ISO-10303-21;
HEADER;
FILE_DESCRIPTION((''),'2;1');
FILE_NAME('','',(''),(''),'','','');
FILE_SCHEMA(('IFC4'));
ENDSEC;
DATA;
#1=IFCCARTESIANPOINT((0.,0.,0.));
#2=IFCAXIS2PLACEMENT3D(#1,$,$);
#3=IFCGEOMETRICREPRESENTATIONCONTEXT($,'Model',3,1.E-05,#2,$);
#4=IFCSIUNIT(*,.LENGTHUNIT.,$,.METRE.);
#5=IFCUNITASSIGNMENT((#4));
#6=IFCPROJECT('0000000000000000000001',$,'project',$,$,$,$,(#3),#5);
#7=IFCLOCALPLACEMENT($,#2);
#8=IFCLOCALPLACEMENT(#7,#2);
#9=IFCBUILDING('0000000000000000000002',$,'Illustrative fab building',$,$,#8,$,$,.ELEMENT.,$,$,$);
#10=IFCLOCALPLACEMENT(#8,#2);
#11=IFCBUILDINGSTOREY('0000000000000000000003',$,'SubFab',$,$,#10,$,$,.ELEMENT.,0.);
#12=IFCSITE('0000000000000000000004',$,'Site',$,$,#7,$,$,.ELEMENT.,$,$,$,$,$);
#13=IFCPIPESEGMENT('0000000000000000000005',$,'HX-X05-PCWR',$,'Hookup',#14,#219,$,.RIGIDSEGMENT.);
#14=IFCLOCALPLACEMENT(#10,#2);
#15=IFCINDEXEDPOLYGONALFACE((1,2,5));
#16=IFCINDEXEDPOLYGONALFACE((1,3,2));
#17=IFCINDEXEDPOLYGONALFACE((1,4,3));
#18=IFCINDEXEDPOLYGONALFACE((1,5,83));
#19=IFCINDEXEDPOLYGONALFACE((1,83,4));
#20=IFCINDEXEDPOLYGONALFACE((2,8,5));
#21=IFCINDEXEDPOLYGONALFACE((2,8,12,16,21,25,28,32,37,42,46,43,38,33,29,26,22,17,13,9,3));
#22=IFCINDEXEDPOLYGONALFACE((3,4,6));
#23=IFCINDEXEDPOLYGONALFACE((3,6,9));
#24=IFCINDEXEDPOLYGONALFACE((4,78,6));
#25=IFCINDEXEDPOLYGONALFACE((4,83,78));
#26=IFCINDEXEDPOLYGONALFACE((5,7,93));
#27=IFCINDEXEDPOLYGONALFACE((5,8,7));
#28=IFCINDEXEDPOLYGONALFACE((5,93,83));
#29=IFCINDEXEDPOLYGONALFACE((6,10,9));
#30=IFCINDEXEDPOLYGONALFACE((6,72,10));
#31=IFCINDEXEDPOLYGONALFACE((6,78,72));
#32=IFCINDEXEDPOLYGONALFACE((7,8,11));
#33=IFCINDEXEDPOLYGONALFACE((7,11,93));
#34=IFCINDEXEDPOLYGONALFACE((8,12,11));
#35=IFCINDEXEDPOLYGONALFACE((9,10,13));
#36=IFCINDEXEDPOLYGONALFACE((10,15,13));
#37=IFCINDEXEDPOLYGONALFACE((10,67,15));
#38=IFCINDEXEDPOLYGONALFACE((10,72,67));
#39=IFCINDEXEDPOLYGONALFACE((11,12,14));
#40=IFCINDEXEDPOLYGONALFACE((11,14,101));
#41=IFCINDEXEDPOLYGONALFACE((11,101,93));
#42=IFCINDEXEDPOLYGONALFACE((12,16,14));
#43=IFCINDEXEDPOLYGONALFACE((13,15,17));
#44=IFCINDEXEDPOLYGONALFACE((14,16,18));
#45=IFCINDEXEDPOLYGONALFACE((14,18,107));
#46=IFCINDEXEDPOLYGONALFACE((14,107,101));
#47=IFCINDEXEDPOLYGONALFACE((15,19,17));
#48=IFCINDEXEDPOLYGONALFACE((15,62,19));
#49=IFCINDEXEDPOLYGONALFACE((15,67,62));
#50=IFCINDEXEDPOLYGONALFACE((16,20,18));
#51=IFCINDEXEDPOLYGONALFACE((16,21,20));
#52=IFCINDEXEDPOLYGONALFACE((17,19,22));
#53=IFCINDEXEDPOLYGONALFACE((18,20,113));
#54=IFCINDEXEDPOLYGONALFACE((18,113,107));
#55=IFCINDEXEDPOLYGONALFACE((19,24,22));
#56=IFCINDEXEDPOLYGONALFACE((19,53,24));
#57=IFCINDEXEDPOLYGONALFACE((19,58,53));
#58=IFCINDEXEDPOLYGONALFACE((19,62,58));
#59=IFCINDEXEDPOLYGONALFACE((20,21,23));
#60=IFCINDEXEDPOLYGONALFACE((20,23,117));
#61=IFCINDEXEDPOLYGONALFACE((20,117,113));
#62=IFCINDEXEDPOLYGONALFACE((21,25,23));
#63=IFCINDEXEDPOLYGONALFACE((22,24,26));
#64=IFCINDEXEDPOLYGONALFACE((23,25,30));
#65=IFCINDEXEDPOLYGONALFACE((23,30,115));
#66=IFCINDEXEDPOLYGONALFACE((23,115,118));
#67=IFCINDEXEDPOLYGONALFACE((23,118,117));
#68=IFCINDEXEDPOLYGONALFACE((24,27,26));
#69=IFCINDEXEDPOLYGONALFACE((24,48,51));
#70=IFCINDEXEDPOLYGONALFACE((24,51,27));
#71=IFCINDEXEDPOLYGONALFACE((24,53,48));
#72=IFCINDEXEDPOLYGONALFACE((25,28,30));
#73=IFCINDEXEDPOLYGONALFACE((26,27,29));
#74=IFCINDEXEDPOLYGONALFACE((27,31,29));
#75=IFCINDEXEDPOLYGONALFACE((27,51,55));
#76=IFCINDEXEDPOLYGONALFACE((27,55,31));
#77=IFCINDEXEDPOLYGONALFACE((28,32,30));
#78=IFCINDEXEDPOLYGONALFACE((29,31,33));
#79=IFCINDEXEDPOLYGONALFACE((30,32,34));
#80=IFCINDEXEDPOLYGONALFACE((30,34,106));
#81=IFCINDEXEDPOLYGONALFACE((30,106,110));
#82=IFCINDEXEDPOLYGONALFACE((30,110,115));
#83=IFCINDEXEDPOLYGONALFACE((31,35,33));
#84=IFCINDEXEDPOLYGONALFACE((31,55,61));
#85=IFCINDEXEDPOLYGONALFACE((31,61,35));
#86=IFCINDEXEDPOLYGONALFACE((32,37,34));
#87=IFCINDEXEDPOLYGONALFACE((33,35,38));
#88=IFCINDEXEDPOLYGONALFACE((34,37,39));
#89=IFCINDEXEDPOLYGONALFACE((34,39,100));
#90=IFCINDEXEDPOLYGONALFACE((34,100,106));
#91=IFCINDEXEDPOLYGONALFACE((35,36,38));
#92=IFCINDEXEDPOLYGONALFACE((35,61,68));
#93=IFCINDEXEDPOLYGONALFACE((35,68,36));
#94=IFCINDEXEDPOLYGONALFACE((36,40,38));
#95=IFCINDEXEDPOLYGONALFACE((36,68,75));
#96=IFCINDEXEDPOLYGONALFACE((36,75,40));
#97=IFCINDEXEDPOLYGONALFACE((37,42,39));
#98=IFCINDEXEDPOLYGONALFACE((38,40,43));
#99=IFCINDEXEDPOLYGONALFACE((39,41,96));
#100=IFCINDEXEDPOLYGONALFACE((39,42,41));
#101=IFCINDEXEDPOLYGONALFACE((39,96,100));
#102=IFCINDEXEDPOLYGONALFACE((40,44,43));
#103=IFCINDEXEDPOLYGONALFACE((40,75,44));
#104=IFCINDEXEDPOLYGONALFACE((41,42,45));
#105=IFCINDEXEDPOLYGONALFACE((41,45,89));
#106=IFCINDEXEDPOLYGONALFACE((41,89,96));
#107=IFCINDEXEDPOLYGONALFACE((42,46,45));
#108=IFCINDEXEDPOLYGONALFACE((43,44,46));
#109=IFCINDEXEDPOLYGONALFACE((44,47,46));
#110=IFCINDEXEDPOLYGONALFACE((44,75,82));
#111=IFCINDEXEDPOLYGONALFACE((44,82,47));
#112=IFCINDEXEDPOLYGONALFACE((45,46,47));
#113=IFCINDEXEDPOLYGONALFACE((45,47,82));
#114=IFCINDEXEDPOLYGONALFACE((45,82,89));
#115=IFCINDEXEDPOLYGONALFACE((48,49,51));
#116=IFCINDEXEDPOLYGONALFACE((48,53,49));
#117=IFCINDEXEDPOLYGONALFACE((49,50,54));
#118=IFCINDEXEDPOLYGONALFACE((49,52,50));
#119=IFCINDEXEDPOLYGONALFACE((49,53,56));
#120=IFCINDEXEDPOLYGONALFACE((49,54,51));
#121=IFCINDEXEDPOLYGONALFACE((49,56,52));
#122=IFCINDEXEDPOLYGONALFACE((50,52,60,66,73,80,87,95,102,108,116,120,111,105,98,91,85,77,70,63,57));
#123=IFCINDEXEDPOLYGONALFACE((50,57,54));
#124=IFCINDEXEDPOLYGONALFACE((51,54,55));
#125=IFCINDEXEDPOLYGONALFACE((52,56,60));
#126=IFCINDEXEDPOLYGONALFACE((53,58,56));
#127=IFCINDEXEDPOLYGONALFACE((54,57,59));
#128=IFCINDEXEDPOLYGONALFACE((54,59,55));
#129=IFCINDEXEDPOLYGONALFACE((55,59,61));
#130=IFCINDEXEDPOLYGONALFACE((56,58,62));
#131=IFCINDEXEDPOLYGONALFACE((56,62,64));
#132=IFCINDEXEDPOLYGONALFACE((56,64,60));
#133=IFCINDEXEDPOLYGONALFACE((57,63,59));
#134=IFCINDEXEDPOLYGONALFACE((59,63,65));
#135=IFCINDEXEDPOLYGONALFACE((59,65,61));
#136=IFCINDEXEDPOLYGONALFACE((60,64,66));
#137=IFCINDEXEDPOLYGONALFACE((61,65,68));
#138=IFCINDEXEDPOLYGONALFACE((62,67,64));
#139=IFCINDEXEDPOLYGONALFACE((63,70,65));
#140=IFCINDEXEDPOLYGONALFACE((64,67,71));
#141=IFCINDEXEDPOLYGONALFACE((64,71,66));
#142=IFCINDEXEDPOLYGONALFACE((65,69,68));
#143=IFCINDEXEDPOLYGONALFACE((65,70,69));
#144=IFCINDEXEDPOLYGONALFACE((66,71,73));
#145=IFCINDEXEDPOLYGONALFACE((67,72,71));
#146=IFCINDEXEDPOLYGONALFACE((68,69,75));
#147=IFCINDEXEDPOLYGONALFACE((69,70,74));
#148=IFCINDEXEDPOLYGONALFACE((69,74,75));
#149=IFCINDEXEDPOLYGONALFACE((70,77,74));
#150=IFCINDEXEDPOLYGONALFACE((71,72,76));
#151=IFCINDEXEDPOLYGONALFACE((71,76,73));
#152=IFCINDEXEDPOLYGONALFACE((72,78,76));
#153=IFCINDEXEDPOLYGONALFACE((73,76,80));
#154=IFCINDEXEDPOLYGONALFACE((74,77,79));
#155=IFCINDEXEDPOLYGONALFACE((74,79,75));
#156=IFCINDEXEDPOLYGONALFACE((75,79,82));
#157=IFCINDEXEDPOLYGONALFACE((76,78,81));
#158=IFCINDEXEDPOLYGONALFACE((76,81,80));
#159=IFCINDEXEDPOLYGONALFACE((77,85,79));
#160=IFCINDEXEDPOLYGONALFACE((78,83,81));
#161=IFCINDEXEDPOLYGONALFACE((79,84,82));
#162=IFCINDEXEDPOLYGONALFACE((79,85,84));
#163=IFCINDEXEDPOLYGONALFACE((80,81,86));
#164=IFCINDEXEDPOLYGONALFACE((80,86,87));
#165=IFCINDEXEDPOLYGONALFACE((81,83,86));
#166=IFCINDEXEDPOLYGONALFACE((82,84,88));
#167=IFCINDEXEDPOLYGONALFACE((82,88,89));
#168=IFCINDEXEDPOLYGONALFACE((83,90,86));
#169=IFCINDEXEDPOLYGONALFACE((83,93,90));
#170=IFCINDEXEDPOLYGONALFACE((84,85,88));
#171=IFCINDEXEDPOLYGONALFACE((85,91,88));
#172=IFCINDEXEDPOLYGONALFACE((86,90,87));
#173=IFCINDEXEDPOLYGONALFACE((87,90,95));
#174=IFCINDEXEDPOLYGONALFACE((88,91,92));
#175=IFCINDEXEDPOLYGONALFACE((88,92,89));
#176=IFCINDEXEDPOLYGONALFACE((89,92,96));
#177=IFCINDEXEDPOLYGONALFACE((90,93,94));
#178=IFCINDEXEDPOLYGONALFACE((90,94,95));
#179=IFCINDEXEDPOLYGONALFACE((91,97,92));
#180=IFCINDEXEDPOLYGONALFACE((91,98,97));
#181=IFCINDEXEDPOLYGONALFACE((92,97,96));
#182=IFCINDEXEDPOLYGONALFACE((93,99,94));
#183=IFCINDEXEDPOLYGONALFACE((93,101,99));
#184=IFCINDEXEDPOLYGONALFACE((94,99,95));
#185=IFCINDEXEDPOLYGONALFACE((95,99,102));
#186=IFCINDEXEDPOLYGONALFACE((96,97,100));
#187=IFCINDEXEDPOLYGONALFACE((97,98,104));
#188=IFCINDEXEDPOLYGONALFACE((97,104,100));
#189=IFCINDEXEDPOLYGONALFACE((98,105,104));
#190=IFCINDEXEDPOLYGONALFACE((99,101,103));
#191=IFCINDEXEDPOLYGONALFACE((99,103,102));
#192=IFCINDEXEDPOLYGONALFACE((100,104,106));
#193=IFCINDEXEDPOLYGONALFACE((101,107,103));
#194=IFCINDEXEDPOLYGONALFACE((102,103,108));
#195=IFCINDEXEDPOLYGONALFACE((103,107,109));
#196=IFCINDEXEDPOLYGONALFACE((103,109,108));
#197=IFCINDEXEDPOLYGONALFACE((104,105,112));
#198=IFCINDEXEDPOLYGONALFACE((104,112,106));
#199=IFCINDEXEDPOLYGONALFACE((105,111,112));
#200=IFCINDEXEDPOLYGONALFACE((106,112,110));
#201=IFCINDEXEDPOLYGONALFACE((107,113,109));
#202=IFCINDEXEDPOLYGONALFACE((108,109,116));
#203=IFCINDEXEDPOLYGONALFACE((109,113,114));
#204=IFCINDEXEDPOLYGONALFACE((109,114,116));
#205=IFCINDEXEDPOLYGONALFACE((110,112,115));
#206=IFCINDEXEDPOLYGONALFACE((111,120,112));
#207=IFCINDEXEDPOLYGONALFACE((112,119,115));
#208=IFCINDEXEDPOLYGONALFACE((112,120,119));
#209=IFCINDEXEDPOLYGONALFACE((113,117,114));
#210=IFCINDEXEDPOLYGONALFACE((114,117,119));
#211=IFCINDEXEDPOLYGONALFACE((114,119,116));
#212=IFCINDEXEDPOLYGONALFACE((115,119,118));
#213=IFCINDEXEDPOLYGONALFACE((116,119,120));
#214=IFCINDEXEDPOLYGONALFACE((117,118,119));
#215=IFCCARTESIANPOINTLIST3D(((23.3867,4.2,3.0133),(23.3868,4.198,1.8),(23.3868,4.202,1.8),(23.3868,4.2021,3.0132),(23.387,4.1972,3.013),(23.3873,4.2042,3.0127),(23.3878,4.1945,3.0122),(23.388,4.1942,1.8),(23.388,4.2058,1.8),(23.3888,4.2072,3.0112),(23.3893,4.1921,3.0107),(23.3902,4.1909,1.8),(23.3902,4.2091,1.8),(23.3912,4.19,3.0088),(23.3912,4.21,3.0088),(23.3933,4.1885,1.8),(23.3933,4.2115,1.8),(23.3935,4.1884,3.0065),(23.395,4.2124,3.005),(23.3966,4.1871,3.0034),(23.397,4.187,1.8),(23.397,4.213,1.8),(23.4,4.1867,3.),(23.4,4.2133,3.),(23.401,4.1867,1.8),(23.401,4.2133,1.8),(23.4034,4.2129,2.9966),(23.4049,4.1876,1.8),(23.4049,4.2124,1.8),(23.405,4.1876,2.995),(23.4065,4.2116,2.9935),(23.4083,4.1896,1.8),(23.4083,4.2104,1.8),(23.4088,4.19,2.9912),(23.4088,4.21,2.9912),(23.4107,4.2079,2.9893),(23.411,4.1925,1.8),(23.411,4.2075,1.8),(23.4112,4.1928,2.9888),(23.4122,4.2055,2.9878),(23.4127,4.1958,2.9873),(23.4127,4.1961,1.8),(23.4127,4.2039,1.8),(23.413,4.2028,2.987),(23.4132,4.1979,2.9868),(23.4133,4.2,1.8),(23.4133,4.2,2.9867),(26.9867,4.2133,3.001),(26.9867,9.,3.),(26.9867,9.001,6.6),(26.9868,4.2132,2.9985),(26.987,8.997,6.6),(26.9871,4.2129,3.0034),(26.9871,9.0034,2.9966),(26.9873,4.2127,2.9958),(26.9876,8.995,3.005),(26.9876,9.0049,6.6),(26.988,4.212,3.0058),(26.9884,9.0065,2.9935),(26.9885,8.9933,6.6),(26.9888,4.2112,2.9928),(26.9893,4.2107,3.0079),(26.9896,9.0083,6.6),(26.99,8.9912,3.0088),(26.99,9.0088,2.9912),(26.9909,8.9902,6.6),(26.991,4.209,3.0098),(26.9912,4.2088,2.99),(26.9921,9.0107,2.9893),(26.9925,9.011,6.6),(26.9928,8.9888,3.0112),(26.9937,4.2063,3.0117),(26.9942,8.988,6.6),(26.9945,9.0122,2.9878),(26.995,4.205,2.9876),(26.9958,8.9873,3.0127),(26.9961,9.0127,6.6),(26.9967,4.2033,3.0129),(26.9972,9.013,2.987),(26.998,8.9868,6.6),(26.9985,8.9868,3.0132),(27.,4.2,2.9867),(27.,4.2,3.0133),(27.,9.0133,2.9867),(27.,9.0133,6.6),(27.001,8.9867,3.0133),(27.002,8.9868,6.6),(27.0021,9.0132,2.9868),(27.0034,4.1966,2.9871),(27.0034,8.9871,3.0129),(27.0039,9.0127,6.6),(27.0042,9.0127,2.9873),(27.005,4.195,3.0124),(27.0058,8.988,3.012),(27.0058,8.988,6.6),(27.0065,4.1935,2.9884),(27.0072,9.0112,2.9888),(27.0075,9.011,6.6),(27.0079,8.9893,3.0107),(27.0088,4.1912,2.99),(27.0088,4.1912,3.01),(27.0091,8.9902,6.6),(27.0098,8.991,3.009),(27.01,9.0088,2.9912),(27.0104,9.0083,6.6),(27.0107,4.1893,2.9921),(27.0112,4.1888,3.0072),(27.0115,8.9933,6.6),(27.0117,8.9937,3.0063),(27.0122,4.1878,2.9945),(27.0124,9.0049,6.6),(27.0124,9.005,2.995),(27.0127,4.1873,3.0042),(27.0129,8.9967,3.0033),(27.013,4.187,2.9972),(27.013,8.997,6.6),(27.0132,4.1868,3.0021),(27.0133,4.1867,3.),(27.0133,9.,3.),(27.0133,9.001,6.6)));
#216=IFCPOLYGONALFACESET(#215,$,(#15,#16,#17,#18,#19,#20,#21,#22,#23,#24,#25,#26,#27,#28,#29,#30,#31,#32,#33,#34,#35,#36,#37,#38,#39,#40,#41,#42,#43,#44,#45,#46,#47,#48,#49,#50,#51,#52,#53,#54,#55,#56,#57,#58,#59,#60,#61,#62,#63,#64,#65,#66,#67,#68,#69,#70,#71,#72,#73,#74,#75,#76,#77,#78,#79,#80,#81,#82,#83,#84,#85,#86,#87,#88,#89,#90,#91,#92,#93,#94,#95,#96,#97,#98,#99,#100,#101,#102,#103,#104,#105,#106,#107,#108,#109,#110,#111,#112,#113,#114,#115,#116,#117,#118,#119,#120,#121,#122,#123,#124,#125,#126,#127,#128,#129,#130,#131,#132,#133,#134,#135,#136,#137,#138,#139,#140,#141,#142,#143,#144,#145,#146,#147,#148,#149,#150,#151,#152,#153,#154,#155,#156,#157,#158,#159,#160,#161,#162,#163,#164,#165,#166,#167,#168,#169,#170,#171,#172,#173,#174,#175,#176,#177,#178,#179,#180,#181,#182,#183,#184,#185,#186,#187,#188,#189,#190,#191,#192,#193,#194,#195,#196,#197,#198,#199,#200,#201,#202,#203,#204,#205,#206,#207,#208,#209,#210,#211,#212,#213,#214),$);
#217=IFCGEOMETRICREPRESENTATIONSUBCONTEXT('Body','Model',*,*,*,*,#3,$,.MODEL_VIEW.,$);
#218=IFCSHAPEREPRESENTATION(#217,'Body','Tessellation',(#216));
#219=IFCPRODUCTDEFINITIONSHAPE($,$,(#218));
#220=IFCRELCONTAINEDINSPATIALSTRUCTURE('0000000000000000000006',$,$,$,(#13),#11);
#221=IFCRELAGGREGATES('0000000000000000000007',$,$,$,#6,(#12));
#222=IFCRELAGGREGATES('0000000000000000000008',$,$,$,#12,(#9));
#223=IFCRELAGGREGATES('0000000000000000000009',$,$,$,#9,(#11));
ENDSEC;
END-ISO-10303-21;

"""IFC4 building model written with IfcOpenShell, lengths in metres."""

from ifc_helpers import new_model, entity, si_unit, origin, place, context, subcontext, project, spatial, element, save


model = new_model("IFC4")

# Units and contexts
model_context = context("Model", 3, precision=1e-05, world=origin())
body_context = subcontext(model_context, "Body", "Model", "MODEL_VIEW")
ifc_project = project(units=[si_unit("LENGTHUNIT", "METRE")], contexts=[model_context])

# Site, building, storey
site_placement = place(None, origin())
site = spatial("IfcSite", under=ifc_project, at=site_placement, Name="Site", CompositionType="ELEMENT")
building_placement = place(site_placement, origin())
building = spatial("IfcBuilding", under=site, at=building_placement, Name="Illustrative fab building", CompositionType="ELEMENT")
storey_placement = place(building_placement, origin())
storey = spatial("IfcBuildingStorey", under=building, at=storey_placement, Name="SubFab", CompositionType="ELEMENT", Elevation=0.0)

# Pipe segment
pipe_segment_1_placement = place(storey_placement, origin())
element("IfcPipeSegment", 1, at=pipe_segment_1_placement, inside=storey, Name="HX-X05-PCWR", ObjectType="Hookup", PredefinedType="RIGIDSEGMENT", context=body_context, shape_type="AdvancedSweptSolid", body=[
    entity("IfcSweptDiskSolid", entity("IfcPolyline", [entity("IfcCartesianPoint", [23.4, 4.2, 1.8]), entity("IfcCartesianPoint", [23.4, 4.2, 3.0]), entity("IfcCartesianPoint", [27.0, 4.2, 3.0]), entity("IfcCartesianPoint", [27.0, 9.0, 3.0]), entity("IfcCartesianPoint", [27.0, 9.0, 6.6])]), 0.0133),
])

save(model, "model.ifc")
